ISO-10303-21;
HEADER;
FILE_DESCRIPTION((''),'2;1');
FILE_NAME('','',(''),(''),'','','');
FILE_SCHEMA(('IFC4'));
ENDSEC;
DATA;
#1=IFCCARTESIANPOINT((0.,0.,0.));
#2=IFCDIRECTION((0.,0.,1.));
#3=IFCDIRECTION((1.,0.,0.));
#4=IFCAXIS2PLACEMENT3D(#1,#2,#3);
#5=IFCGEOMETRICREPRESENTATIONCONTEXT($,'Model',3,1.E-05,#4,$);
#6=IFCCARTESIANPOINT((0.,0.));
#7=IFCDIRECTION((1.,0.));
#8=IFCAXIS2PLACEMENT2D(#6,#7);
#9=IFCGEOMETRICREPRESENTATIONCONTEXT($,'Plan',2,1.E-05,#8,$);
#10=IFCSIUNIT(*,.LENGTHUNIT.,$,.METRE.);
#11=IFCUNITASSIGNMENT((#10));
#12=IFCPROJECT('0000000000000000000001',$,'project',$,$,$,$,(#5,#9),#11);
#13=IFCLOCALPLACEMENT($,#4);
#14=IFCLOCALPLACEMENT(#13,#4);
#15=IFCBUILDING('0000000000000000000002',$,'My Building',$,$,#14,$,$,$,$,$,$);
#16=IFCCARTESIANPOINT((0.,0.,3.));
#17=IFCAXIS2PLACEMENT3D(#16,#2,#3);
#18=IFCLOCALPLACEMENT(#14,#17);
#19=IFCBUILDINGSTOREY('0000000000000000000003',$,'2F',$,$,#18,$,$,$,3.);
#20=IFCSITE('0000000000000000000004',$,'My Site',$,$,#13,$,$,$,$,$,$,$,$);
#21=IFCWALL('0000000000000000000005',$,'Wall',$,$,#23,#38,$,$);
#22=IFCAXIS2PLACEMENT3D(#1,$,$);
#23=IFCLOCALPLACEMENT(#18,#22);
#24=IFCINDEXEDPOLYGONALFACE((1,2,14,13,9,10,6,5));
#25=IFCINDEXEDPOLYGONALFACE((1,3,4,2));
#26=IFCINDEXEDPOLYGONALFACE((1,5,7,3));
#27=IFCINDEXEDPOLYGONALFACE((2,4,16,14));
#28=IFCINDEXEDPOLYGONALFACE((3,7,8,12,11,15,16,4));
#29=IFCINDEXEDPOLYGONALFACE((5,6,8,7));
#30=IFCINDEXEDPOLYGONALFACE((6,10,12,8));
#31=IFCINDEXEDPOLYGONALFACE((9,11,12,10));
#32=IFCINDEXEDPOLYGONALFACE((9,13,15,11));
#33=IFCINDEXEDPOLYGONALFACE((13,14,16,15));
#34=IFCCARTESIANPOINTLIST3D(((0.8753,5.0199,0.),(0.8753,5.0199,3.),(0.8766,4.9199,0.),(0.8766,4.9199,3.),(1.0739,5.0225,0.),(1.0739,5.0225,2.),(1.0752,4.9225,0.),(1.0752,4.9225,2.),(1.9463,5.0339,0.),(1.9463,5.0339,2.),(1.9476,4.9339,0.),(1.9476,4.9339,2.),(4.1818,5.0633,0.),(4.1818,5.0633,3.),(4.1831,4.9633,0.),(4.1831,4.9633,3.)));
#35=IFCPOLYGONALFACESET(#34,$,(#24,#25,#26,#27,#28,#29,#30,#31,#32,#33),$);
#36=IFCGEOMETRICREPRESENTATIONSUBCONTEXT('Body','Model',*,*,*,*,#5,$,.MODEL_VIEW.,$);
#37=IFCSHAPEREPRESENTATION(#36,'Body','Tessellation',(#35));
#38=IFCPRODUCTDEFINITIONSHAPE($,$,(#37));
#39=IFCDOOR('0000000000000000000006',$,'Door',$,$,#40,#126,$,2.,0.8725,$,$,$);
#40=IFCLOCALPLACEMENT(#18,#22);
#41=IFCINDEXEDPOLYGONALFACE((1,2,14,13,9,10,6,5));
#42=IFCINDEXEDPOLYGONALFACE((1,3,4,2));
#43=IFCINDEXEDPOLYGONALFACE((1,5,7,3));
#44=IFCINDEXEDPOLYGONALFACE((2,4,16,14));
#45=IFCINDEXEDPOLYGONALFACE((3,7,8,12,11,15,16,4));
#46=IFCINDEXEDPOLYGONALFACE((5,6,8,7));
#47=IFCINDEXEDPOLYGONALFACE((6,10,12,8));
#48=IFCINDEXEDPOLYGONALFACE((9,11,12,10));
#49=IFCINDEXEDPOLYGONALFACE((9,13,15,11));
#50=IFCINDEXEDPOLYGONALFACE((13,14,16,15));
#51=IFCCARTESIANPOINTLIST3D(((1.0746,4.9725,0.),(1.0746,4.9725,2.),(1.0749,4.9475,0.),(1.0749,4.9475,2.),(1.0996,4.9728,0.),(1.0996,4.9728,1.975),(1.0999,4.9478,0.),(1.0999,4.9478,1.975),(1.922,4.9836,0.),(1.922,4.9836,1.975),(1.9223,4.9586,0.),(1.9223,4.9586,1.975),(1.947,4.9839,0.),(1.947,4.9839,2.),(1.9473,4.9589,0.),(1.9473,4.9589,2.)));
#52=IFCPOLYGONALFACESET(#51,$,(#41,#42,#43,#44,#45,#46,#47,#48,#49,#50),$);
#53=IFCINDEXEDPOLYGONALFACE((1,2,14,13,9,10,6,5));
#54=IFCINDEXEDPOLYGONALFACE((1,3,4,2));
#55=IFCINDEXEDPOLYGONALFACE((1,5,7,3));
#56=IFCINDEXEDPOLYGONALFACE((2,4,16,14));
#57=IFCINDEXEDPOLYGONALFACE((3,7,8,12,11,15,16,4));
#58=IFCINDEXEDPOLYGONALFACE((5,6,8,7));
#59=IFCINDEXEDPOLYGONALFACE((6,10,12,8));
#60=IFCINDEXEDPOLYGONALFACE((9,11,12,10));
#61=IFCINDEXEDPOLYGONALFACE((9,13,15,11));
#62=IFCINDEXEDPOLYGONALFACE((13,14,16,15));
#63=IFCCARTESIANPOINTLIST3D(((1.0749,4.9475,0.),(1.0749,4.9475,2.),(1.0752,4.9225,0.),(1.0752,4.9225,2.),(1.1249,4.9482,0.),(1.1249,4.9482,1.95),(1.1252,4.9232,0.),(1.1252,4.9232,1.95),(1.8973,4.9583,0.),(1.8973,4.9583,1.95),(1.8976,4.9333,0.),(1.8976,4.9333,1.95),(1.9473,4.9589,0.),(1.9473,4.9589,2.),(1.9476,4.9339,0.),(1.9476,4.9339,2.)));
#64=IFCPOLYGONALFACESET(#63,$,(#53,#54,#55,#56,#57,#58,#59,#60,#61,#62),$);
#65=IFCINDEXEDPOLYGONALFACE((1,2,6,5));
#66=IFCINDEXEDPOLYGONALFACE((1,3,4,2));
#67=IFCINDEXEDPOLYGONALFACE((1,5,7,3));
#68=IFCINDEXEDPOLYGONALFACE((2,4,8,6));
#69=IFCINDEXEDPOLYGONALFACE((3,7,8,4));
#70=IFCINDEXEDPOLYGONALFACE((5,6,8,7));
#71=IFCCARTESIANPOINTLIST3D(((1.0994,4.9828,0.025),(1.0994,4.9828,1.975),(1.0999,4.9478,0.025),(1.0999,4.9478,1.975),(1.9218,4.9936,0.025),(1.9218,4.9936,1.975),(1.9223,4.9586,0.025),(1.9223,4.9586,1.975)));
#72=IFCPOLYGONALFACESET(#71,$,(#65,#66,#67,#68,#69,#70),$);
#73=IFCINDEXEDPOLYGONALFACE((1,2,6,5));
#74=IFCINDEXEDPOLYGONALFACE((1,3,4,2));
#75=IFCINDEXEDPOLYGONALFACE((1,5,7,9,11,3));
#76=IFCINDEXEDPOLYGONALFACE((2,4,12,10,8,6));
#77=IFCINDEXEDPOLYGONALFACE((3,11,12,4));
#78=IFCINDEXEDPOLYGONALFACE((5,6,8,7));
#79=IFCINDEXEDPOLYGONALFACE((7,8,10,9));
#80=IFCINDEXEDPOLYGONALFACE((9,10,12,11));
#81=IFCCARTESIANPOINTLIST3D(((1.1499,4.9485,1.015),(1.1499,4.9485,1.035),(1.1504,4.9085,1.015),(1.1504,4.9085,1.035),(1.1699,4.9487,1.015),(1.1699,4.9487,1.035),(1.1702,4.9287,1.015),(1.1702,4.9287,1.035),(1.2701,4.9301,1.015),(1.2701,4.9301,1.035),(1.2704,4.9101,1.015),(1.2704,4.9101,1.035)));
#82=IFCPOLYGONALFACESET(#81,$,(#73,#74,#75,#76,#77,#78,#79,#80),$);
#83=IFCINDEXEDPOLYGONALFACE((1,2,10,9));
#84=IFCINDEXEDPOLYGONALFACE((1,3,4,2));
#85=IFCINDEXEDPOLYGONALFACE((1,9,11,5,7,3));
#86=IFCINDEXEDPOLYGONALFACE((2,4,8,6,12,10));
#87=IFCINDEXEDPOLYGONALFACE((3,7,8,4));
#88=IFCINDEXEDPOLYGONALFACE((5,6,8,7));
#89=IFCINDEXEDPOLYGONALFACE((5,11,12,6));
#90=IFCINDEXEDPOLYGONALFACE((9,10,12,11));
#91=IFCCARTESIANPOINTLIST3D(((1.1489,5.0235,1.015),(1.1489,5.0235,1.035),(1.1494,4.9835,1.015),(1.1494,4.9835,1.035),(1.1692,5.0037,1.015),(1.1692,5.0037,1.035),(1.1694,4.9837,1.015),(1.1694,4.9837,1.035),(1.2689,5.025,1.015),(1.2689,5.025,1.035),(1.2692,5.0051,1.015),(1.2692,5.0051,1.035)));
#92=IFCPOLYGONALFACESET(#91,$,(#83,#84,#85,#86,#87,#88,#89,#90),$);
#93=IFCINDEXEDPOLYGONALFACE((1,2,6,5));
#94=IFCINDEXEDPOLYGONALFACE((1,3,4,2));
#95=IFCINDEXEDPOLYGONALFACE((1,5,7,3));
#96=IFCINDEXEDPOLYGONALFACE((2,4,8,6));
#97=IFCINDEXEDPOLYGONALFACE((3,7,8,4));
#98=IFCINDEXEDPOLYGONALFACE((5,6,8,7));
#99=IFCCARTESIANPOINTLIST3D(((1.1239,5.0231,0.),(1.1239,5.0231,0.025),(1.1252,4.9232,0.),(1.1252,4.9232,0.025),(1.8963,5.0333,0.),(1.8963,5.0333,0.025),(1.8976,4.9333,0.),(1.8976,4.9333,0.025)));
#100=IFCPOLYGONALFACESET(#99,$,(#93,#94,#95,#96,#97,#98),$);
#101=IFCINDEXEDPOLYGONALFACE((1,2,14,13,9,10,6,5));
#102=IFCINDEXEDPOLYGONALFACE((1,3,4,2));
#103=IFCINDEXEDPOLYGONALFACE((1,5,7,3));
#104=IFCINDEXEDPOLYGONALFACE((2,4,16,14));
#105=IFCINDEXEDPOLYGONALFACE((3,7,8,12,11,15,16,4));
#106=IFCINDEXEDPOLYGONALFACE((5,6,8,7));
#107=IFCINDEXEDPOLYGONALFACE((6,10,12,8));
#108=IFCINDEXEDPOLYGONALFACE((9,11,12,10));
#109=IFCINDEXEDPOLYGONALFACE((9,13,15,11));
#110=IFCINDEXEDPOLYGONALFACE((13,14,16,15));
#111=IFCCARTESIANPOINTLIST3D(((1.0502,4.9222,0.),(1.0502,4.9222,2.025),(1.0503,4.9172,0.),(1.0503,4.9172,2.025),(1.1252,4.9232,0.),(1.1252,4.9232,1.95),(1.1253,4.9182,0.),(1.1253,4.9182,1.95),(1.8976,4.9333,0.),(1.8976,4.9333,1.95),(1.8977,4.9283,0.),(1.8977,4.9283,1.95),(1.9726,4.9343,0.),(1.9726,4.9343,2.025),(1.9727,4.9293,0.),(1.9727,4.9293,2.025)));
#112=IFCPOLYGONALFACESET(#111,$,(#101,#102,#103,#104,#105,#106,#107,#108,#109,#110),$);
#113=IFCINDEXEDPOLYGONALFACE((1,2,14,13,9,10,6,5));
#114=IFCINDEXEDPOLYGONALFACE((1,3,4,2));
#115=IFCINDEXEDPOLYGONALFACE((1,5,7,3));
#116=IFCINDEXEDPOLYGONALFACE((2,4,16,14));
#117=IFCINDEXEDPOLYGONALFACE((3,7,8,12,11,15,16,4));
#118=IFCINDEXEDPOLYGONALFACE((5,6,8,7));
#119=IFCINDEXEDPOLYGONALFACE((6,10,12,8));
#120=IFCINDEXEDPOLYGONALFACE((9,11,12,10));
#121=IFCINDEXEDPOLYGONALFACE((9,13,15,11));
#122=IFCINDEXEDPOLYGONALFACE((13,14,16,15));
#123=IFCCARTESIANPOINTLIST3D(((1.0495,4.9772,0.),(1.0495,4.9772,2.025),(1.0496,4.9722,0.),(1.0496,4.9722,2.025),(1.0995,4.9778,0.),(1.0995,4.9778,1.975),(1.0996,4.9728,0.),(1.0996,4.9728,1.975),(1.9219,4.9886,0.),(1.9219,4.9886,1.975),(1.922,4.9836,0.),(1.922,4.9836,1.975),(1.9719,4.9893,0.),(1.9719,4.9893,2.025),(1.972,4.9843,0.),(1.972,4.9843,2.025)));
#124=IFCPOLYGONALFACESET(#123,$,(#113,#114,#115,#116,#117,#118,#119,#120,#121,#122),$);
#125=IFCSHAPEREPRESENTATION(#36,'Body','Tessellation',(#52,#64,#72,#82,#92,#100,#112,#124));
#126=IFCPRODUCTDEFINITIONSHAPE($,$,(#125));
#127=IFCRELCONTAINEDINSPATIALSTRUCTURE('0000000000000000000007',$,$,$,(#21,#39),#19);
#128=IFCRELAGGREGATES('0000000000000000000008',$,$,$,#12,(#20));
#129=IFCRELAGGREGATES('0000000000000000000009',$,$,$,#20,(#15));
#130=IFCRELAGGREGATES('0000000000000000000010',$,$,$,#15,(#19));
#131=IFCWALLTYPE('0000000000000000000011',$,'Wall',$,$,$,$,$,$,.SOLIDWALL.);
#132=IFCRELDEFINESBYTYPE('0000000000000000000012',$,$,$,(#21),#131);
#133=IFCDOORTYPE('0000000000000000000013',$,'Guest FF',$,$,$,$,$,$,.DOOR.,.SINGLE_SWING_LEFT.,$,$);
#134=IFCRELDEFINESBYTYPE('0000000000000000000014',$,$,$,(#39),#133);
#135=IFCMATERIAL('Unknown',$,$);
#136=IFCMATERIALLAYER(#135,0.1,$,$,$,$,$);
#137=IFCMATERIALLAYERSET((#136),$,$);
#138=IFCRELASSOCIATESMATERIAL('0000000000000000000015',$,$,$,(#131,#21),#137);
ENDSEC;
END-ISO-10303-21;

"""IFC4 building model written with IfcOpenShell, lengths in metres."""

from ifc_helpers import new_model, entity, si_unit, frame, origin_with_axes, origin_2d_with_axis, place, context, subcontext, project, spatial, line, indexed_curve, outline, extrude, shape, source, transform, mapped, material, layer, layer_set, layer_usage, type_object, type_shapes, element, fill, save


model = new_model("IFC4")

# Units and contexts
model_context = context("Model", 3, precision=1e-05, world=origin_with_axes())
plan_context = context("Plan", 2, precision=1e-05, world=origin_2d_with_axis())
body_context_1 = subcontext(model_context, "Body", "Model", "MODEL_VIEW")
body_context_2 = subcontext(plan_context, "Body", "Plan", "PLAN_VIEW")
ifc_project = project(units=[si_unit("LENGTHUNIT", "METRE")], contexts=[model_context, plan_context])

# Site, building, storey
site_placement = place(None, origin_with_axes())
site = spatial("IfcSite", under=ifc_project, at=site_placement, Name="My Site")
building_placement = place(site_placement, origin_with_axes())
building = spatial("IfcBuilding", under=site, at=building_placement, Name="My Building")
storey_placement = place(building_placement, frame((0.0, 0.0, 3.0), z_axis=(0.0, 0.0, 1.0), x_axis=(1.0, 0.0, 0.0)))
storey = spatial("IfcBuildingStorey", under=building, at=storey_placement, Name="2F", Elevation=3.0)

# Shared definitions
ifc_material = material(Name="Unknown")

# Shared definitions
ifc_layer_1 = layer(ifc_material, 0.1)
ifc_layer_set_1 = layer_set([ifc_layer_1])
wall_type = type_object("IfcWallType", Name="Wall", PredefinedType="SOLIDWALL", material=ifc_layer_set_1)

# Shared definitions
shared_shape_1 = source(origin_with_axes(), body_context_1, "Body", "SweptSolid", [
    extrude(outline(indexed_curve([(0.0, 0.0), (0.8725, 0.0), (0.8725, 2.0), (0.0, 2.0)], segments=[line(1, 2, 3, 4, 1)])), frame((0.0, -0.6, 0.0), z_axis=(0.0, -1.0, 0.0), x_axis=(1.0, 0.0, 0.0)), (0.0, 0.0, -1.0), 1.2),
])
door_type_1 = type_object("IfcDoorType", Name="Guest FF", OperationType="SINGLE_SWING_LEFT", PredefinedType="DOOR")
shared_shape_2 = source(origin_with_axes(), body_context_1, "Body", "SweptSolid", [
    extrude(outline(indexed_curve([(0.0, 0.0), (0.0, 2.0), (0.8725, 2.0), (0.8725, 0.0), (0.8475, 0.0), (0.8475, 1.975), (0.025, 1.975), (0.025, 0.0)], segments=[line(1, 2, 3, 4, 5, 6, 7, 8, 1)])), frame((0.0, 0.025, 0.0), z_axis=(0.0, -1.0, 0.0), x_axis=(1.0, 0.0, 0.0)), (0.0, 0.0, -1.0), 0.025),
    extrude(outline(indexed_curve([(0.0, 0.0), (0.0, 2.0), (0.8725, 2.0), (0.8725, 0.0), (0.8225, 0.0), (0.8225, 1.95), (0.05, 1.95), (0.05, 0.0)], segments=[line(1, 2, 3, 4, 5, 6, 7, 8, 1)])), frame((0.0, 0.0, 0.0), z_axis=(0.0, -1.0, 0.0), x_axis=(1.0, 0.0, 0.0)), (0.0, 0.0, -1.0), 0.025),
    extrude(outline(indexed_curve([(0.0, 0.0), (0.8225, 0.0), (0.8225, 0.035), (0.0, 0.035)], segments=[line(1, 2, 3, 4, 1)])), frame((0.025, 0.025, 0.025), z_axis=(0.0, 0.0, 1.0), x_axis=(1.0, 0.0, 0.0)), (0.0, 0.0, 1.0), 1.95),
    extrude(outline(indexed_curve([(0.0, 0.0), (0.0, -0.04), (0.12, -0.04), (0.12, -0.02), (0.02, -0.02), (0.02, 0.0)], segments=[line(1, 2, 3, 4, 5, 6, 1)])), frame((0.075, 0.025, 1.015), z_axis=(0.0, 0.0, 1.0), x_axis=(1.0, 0.0, 0.0)), (0.0, 0.0, 1.0), 0.02),
    extrude(outline(indexed_curve([(0.0, 0.0), (0.0, 0.04), (0.12, 0.04), (0.12, 0.02), (0.02, 0.02), (0.02, 0.0)], segments=[line(1, 2, 3, 4, 5, 6, 1)])), frame((0.075, 0.06, 1.015), z_axis=(0.0, 0.0, 1.0), x_axis=(1.0, 0.0, 0.0)), (0.0, 0.0, 1.0), 0.02),
    extrude(outline(indexed_curve([(0.0, 0.0), (0.7725, 0.0), (0.7725, 0.1), (0.0, 0.1)], segments=[line(1, 2, 3, 4, 1)])), frame((0.05, 0.0, 0.0), z_axis=(0.0, 0.0, 1.0), x_axis=(1.0, 0.0, 0.0)), (0.0, 0.0, 1.0), 0.025),
    extrude(outline(indexed_curve([(0.0, 0.0), (0.0, 2.025), (0.9225, 2.025), (0.9225, 0.0), (0.8475, 0.0), (0.8475, 1.95), (0.075, 1.95), (0.075, 0.0)], segments=[line(1, 2, 3, 4, 5, 6, 7, 8, 1)])), frame((-0.025, -0.005, 0.0), z_axis=(0.0, -1.0, 0.0), x_axis=(1.0, 0.0, 0.0)), (0.0, 0.0, -1.0), 0.005),
    extrude(outline(indexed_curve([(0.0, 0.0), (0.0, 2.025), (0.9225, 2.025), (0.9225, 0.0), (0.8725, 0.0), (0.8725, 1.975), (0.05, 1.975), (0.05, 0.0)], segments=[line(1, 2, 3, 4, 5, 6, 7, 8, 1)])), frame((-0.025, 0.05, 0.0), z_axis=(0.0, -1.0, 0.0), x_axis=(1.0, 0.0, 0.0)), (0.0, 0.0, -1.0), 0.005),
])
shared_shape_3 = source(origin_with_axes(), body_context_2, "Body", "Curve2D", [
    entity("IfcIndexedPolyCurve", entity("IfcCartesianPointList2D", [[0.0, 0.0], [0.0, 0.05], [0.025, 0.05], [0.025, 0.025], [0.05, 0.025], [0.05, 0.0]]), [entity("IfcLineIndex", [1, 2, 3, 4, 5, 6, 1])]),
    entity("IfcIndexedPolyCurve", entity("IfcCartesianPointList2D", [[0.8725, 0.0], [0.8725, 0.05], [0.8475, 0.05], [0.8475, 0.025], [0.8225, 0.025], [0.8225, 0.0]]), [entity("IfcLineIndex", [1, 2, 3, 4, 5, 6, 1])]),
    entity("IfcTrimmedCurve", entity("IfcEllipse", entity("IfcAxis2Placement2D", entity("IfcCartesianPoint", [0.8125, 0.05]), entity("IfcDirection", [1.0, 0.0])), 0.7875, 0.8225), [entity("IfcCartesianPoint", [0.8125, 0.8725])], [entity("IfcCartesianPoint", [0.025, 0.05])], True, "CARTESIAN"),
    entity("IfcIndexedPolyCurve", entity("IfcCartesianPointList2D", [[0.8475, 0.05], [0.8125, 0.05], [0.8125, 0.8725], [0.8475, 0.8725]]), [entity("IfcLineIndex", [1, 2, 3, 4, 1])]),
])
type_shapes(door_type_1, [shared_shape_2, shared_shape_3])

# Wall, opening, door
ifc_layer_usage_1 = layer_usage(ifc_layer_set_1, "AXIS2", "POSITIVE", 0.0)
wall_1_placement = place(storey_placement, frame((0.8766, 4.9199, 0.0), z_axis=(0.0, 0.0, 1.0), x_axis=(0.999914, 0.01312, 0.0)))
wall_1 = element("IfcWall", 1, at=wall_1_placement, inside=storey, type_object=wall_type, material=ifc_layer_usage_1, Name="Wall", context=body_context_1, shape_type="SweptSolid", body=[
    extrude(outline(indexed_curve([(0.0, 0.0), (0.0, 0.1), (3.3068, 0.1), (3.3068, 0.0)], segments=[line(1, 2, 3, 4, 1)])), origin_with_axes(), (0.0, 0.0, 1.0), 3.0),
])
opening_1_placement = place(wall_1_placement, frame((0.1986, 0.0, 0.0), z_axis=(0.0, 0.0, 1.0), x_axis=(1.0, 0.0, 0.0)))
opening_1 = element("IfcOpeningElement", 2, at=opening_1_placement, cuts=wall_1, PredefinedType="OPENING", context=body_context_1, shape_type="MappedRepresentation", body=[
    mapped(shared_shape_1, transform((0.0, 0.0, 0.0), x_axis=(1.0, 0.0, 0.0), y_axis=(0.0, 1.0, 0.0), z_axis=(0.0, 0.0, 1.0), scale=1.0)),
])
door_1_placement = place(opening_1_placement, frame((0.0, 0.0, 0.0), z_axis=(0.0, 0.0, 1.0), x_axis=(1.0, 0.0, 0.0)))
door_1 = element("IfcDoor", 3, at=door_1_placement, inside=storey, type_object=door_type_1, Name="Door", OverallHeight=2.0, OverallWidth=0.8725, shapes=[
    shape(body_context_1, "Body", "MappedRepresentation", [mapped(shared_shape_2, transform((0.0, 0.0, 0.0), x_axis=(1.0, 0.0, 0.0), y_axis=(0.0, 1.0, 0.0), z_axis=(0.0, 0.0, 1.0), scale=1.0))]),
    shape(body_context_2, "Body", "MappedRepresentation", [mapped(shared_shape_3, transform((0.0, 0.0, 0.0), x_axis=(1.0, 0.0, 0.0), y_axis=(0.0, 1.0, 0.0), z_axis=(0.0, 0.0, 1.0), scale=1.0))]),
])
fill(opening_1, door_1)

save(model, "model.ifc")
